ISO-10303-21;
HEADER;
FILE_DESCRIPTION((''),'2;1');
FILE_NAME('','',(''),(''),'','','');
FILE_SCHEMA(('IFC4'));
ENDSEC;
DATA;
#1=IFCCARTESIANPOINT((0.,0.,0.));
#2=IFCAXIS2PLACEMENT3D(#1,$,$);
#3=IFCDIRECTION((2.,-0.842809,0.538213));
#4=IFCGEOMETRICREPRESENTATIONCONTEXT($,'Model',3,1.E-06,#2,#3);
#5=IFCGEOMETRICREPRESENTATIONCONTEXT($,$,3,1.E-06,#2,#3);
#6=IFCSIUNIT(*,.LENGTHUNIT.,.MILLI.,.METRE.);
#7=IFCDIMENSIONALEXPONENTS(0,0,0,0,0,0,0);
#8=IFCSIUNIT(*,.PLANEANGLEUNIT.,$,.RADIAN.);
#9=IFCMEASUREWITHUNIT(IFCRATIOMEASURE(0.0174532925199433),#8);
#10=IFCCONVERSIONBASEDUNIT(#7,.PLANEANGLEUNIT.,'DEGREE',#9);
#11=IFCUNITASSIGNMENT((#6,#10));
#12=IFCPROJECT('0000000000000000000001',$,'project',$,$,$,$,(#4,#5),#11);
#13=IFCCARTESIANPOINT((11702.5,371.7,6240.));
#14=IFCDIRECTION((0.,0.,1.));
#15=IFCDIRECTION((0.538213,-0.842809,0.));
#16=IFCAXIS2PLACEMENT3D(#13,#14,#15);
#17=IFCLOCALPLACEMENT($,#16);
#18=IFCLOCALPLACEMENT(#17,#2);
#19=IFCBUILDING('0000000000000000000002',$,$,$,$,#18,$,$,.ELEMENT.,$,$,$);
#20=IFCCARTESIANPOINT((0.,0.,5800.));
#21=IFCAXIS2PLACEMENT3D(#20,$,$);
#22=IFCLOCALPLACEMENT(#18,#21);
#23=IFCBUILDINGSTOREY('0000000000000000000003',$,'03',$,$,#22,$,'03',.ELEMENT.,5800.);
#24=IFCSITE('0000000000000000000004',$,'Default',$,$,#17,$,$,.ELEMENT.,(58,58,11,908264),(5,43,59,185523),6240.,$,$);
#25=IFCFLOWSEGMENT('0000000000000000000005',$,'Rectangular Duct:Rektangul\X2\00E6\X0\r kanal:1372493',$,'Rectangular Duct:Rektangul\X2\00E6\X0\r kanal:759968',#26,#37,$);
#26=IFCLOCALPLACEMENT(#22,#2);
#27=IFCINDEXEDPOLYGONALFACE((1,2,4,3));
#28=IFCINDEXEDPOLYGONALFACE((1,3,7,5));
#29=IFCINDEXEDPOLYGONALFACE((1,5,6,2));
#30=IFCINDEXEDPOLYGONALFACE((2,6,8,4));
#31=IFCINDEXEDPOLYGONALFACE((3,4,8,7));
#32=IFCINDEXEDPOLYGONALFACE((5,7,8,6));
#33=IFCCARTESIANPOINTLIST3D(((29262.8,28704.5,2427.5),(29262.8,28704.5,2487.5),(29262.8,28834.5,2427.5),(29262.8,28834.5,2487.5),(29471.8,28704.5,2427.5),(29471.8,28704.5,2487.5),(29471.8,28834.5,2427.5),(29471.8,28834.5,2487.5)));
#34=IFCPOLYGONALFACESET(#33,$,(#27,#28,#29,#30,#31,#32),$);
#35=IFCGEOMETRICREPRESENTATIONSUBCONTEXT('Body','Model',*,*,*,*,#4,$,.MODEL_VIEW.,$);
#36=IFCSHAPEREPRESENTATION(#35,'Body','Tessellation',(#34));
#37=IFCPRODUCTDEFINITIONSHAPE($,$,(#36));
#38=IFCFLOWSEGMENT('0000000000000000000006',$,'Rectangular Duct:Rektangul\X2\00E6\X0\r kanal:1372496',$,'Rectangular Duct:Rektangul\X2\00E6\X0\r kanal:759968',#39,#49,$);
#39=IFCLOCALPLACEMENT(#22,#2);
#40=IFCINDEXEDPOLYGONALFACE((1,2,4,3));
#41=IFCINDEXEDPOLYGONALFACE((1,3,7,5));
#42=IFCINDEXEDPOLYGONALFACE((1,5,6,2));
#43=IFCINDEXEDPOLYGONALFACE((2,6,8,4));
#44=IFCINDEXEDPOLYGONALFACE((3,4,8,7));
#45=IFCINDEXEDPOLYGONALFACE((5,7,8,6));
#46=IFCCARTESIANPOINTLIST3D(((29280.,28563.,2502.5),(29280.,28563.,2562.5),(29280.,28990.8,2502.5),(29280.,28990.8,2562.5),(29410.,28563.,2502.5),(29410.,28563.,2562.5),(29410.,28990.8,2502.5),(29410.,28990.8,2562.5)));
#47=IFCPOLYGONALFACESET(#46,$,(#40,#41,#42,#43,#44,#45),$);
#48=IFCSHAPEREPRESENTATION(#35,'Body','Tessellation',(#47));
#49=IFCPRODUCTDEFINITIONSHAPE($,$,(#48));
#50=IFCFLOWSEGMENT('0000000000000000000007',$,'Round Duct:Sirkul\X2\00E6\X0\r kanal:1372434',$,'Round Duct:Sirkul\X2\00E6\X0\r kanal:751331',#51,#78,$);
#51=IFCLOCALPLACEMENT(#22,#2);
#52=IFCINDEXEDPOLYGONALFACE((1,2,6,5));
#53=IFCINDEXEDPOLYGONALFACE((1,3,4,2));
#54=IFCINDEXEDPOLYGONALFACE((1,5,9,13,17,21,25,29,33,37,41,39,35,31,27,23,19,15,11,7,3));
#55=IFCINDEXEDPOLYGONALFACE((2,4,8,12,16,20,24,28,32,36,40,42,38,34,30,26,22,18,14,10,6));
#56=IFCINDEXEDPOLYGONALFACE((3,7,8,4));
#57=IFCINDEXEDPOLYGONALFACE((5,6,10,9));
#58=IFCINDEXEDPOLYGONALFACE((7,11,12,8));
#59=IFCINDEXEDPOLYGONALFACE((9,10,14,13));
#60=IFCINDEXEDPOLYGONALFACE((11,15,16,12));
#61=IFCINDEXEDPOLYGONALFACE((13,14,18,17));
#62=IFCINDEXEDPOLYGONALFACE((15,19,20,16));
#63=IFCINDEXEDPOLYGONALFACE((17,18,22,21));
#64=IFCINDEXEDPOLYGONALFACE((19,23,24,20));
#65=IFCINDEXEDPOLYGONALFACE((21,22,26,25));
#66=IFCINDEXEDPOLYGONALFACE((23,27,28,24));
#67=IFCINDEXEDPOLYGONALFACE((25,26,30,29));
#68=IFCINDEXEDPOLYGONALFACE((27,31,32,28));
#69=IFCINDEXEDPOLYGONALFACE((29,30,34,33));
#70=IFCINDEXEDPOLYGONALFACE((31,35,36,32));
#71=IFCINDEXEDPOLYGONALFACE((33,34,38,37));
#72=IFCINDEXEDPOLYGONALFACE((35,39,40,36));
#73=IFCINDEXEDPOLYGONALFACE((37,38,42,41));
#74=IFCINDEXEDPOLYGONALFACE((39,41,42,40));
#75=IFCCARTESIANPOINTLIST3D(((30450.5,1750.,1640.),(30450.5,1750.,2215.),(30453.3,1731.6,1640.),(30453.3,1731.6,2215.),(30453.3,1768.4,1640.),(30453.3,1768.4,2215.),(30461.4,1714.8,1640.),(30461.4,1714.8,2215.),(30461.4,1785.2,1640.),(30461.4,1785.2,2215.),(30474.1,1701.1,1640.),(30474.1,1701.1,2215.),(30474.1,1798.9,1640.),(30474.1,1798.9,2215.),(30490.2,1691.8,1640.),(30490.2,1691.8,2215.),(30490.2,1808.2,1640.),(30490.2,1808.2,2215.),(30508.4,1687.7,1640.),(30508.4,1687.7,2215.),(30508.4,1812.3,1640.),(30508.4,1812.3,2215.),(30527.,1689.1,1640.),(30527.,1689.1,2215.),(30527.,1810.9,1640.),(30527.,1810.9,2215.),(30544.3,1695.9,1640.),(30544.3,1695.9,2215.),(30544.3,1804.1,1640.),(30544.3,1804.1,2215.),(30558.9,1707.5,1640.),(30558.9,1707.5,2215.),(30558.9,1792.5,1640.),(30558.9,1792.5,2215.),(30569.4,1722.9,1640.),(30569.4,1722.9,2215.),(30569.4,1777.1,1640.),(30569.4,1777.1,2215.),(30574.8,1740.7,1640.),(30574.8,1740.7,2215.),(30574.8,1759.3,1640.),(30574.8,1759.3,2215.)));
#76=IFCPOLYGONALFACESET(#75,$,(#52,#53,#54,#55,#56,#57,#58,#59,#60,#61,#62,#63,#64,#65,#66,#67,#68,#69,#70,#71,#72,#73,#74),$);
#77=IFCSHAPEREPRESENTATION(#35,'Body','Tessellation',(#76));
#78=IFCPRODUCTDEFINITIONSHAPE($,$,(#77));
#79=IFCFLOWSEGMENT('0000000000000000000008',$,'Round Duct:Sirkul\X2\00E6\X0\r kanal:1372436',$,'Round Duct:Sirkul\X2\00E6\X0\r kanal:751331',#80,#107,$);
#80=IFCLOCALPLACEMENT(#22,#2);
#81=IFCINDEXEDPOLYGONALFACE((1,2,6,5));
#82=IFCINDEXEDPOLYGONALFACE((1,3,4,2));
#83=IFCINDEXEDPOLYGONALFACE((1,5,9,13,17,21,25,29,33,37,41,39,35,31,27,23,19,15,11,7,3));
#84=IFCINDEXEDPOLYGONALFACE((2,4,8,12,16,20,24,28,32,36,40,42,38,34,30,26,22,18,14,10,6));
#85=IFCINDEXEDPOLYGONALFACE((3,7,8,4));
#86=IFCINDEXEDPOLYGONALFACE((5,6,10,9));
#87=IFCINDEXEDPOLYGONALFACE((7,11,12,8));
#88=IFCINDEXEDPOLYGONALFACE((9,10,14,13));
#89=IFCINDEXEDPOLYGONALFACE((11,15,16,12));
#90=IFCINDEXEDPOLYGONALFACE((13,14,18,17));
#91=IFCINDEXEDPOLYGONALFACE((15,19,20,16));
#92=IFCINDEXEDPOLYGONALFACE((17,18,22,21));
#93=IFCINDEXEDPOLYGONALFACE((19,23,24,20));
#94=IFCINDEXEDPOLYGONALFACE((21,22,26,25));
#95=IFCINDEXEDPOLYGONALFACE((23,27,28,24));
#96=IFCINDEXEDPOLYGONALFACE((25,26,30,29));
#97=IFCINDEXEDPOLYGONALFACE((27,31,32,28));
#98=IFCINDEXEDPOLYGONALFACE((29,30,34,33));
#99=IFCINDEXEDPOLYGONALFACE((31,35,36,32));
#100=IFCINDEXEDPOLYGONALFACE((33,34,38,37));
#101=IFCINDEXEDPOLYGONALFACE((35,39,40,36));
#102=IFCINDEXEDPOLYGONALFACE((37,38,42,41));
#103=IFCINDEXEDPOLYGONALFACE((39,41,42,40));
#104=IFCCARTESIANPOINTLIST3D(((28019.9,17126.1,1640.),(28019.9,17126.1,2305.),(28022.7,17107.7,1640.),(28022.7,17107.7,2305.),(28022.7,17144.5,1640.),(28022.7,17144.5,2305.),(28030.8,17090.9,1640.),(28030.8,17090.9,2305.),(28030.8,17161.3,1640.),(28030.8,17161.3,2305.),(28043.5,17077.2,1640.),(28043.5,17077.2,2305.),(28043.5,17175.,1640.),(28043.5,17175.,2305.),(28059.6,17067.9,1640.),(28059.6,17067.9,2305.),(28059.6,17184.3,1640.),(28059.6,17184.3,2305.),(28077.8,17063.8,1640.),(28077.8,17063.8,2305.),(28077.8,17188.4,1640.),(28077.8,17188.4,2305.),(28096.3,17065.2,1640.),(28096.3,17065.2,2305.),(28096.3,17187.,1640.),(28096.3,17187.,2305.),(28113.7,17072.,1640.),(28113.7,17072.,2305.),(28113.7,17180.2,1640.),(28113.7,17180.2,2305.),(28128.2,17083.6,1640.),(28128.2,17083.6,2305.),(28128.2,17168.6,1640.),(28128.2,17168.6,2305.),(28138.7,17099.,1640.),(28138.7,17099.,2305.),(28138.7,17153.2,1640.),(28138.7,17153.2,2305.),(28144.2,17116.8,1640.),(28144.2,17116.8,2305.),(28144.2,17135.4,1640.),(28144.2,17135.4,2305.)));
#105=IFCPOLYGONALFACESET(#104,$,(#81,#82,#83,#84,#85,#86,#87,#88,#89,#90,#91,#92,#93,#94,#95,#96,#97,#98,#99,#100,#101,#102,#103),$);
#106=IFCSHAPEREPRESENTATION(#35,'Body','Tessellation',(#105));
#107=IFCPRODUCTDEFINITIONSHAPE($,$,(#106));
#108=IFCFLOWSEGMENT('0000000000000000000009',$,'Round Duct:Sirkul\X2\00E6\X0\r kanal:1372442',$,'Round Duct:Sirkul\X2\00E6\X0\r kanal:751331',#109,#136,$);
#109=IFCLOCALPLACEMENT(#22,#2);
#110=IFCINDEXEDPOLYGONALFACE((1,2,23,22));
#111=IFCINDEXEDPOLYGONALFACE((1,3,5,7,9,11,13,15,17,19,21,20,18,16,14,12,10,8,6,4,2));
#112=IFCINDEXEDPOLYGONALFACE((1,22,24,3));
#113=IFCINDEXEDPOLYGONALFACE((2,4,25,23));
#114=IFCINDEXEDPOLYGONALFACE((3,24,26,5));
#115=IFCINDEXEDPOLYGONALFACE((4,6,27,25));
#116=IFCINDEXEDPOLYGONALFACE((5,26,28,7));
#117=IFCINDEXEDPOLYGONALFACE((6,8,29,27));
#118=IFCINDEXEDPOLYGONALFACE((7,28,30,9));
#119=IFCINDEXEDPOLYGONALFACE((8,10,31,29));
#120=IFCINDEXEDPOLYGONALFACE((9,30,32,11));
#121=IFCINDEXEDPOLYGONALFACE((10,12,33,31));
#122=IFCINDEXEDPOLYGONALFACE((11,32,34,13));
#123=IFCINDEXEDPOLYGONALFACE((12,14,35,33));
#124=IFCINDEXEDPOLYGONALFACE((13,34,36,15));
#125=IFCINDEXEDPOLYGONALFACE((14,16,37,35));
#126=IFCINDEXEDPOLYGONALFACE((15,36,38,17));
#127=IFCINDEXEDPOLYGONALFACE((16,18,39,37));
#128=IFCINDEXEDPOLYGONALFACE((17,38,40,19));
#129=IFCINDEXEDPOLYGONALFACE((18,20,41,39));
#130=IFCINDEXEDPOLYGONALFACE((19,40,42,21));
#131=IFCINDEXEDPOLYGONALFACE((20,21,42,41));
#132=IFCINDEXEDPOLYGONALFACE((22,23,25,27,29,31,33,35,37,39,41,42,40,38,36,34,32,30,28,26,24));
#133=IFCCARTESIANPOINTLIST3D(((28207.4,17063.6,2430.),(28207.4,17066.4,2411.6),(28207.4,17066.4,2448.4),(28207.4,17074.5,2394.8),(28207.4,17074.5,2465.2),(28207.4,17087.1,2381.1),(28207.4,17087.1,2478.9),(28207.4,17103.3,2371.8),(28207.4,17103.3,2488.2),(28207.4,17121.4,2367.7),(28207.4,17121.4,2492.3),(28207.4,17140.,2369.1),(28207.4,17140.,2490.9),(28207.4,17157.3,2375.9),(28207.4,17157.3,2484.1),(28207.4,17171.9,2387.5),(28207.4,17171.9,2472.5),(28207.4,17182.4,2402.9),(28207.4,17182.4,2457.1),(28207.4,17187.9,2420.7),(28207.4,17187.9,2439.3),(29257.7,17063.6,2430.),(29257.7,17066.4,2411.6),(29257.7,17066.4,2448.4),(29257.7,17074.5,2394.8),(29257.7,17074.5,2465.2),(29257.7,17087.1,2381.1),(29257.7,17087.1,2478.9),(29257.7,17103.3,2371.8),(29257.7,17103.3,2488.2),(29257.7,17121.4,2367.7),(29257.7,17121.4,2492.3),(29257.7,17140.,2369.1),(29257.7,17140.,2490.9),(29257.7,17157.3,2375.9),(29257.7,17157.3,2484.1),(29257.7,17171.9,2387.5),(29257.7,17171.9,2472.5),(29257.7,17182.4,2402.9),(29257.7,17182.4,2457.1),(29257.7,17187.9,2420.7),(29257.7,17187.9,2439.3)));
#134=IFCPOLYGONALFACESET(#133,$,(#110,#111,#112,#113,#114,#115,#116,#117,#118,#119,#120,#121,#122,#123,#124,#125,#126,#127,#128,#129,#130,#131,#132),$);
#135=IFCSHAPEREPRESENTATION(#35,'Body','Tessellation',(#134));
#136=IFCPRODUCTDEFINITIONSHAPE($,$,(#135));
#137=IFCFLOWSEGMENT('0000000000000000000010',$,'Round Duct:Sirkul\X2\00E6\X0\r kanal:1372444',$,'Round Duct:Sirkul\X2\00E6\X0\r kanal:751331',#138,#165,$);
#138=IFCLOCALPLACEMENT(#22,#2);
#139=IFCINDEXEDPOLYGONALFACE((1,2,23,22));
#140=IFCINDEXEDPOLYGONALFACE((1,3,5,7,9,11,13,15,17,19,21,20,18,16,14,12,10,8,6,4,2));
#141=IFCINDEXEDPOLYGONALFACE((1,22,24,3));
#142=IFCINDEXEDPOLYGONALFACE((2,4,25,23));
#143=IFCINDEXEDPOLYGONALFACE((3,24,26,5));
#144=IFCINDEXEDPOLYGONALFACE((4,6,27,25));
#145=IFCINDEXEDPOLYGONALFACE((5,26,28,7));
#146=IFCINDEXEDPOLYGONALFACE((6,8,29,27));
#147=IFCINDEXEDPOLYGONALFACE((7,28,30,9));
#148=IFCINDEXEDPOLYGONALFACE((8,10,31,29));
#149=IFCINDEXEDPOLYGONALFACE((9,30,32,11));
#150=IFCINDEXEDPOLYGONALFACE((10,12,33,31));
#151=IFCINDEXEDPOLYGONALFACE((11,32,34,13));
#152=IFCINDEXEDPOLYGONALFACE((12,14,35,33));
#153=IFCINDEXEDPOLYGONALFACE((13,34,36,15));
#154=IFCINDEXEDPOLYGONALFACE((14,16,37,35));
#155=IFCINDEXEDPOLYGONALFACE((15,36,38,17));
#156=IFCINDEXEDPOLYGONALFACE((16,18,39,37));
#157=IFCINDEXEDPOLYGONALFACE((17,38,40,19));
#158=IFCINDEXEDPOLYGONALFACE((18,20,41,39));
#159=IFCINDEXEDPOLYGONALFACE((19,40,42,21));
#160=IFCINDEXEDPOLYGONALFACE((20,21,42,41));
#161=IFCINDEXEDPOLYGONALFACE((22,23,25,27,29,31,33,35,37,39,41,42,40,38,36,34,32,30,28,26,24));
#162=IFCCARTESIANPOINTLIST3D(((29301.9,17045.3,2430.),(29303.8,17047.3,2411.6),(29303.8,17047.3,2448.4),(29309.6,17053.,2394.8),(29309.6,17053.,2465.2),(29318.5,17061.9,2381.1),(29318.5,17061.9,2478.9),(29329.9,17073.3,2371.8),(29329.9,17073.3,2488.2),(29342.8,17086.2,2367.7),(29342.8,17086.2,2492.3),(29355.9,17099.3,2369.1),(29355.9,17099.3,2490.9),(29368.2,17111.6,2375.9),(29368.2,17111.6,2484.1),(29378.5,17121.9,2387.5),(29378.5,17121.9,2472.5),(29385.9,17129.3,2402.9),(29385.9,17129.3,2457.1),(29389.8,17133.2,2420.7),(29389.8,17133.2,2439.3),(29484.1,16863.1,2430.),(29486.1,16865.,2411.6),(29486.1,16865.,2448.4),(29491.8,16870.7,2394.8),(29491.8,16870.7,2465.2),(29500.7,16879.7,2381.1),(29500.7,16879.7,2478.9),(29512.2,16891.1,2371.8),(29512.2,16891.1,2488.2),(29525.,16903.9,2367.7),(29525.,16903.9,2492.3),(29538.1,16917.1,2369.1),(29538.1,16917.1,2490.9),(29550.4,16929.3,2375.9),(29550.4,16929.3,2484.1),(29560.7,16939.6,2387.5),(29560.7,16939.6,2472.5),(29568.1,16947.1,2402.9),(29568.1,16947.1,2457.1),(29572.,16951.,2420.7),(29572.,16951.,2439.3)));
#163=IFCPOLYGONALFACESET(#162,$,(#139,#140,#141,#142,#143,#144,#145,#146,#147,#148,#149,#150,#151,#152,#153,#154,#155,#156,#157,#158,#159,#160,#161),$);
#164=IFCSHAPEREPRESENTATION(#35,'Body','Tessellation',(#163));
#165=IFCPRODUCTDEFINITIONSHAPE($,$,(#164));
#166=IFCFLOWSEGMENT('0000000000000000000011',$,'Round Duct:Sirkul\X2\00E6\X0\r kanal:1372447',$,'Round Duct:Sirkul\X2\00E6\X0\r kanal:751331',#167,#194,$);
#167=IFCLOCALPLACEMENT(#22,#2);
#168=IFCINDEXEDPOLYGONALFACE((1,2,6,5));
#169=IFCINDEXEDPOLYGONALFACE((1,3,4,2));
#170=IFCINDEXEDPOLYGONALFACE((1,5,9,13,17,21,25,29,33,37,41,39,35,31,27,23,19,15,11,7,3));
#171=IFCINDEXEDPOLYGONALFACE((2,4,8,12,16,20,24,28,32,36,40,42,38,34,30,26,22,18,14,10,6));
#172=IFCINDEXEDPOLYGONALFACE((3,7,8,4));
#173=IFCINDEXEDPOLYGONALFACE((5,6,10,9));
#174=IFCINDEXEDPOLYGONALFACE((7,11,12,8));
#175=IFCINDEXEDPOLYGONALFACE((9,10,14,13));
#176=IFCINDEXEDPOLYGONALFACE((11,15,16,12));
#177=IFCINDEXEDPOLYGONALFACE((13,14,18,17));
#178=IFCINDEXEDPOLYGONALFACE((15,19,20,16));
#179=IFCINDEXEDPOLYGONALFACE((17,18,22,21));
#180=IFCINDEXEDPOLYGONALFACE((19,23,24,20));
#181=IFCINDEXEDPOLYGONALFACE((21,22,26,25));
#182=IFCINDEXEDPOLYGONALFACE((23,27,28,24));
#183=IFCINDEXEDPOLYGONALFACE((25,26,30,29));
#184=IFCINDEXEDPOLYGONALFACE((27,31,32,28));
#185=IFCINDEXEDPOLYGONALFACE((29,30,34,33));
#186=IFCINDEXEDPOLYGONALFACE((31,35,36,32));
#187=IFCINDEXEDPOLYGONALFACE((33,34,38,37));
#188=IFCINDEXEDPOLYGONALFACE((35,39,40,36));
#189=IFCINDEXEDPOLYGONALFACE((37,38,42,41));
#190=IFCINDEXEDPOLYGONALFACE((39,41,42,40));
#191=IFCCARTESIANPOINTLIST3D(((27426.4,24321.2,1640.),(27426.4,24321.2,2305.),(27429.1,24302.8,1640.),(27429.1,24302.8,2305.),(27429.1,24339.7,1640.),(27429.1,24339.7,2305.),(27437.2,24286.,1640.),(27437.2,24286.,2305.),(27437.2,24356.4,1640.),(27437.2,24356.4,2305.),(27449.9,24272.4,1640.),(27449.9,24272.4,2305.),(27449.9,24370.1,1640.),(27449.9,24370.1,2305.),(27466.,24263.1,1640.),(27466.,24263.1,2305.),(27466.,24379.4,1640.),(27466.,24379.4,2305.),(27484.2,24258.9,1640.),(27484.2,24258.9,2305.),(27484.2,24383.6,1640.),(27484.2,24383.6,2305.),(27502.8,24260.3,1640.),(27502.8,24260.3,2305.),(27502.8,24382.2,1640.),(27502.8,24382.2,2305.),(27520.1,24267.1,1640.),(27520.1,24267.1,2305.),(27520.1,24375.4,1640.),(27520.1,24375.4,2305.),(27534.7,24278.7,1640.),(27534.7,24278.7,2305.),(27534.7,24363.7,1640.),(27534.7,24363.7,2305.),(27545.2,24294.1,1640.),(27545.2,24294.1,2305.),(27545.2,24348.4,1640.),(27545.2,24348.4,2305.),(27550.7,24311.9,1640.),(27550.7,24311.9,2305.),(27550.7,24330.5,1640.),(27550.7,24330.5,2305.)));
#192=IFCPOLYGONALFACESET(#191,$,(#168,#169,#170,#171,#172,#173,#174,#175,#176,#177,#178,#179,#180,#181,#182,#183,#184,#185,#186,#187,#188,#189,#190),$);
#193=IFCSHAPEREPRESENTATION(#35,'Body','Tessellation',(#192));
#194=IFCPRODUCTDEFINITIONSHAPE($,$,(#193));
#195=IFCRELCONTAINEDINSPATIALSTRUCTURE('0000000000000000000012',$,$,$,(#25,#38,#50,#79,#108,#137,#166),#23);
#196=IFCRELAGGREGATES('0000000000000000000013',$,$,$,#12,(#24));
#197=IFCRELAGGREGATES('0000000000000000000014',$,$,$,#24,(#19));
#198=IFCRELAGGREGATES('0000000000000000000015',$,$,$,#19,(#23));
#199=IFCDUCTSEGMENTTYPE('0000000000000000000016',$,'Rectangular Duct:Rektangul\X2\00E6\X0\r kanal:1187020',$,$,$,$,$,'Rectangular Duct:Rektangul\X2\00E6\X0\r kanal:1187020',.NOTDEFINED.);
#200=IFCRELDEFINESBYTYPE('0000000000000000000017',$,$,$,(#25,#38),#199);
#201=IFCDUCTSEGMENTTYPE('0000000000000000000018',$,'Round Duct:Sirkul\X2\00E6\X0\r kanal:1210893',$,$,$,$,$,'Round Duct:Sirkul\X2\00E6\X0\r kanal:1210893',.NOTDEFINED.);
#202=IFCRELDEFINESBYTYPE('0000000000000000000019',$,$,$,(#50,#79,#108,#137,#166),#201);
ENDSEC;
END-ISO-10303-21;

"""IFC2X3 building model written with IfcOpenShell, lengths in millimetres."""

from ifc_helpers import new_model, entity, si_unit, converted_unit, direction, frame, frame_2d, origin, origin_2d_with_axis, place, context, subcontext, project, spatial, rectangle, circle, extrude, type_object, element, save


model = new_model("IFC2X3")

# Units and contexts
model_context = context("Model", 3, precision=1e-06, world=origin(), true_north=direction((2.0, -0.842809, 0.538213)))
context_of_model = context(None, 3, precision=1e-06, world=origin(), true_north=direction((2.0, -0.842809, 0.538213)))
body_context = subcontext(model_context, "Body", "Model", "MODEL_VIEW")
ifc_project = project(units=[si_unit("LENGTHUNIT", "METRE", prefix="MILLI"), converted_unit("PLANEANGLEUNIT", "DEGREE", entity("IfcRatioMeasure", 0.0174532925199433), si_unit("PLANEANGLEUNIT", "RADIAN"), dimensions=[0, 0, 0, 0, 0, 0, 0])], contexts=[model_context, context_of_model])

# Site, building, storey
site_placement = place(None, frame((11702.5, 371.7, 6240.0), z_axis=(0.0, 0.0, 1.0), x_axis=(0.538213, -0.842809, 0.0)))
site = spatial("IfcSite", under=ifc_project, at=site_placement, Name="Default", CompositionType="ELEMENT", RefLatitude=(58, 58, 11, 908264), RefLongitude=(5, 43, 59, 185523), RefElevation=6240.0)
building_placement = place(site_placement, origin())
building = spatial("IfcBuilding", under=site, at=building_placement, CompositionType="ELEMENT")
storey_placement = place(building_placement, frame((0.0, 0.0, 5800.0)))
storey = spatial("IfcBuildingStorey", under=building, at=storey_placement, Name="03", LongName="03", CompositionType="ELEMENT", Elevation=5800.0)

# Flow segments
duct_segment_type_1 = type_object("IfcDuctSegmentType", Name="Rectangular Duct:Rektangulær kanal:1187020", ElementType="Rectangular Duct:Rektangulær kanal:1187020", PredefinedType="NOTDEFINED")
flow_segment_1_placement = place(storey_placement, origin())
element("IfcFlowSegment", 1, at=flow_segment_1_placement, inside=storey, type_object=duct_segment_type_1, Name="Rectangular Duct:Rektangulær kanal:1372493", ObjectType="Rectangular Duct:Rektangulær kanal:759968", context=body_context, shape_type="SweptSolid", body=[
    extrude(rectangle(XDim=208.9, YDim=130.0, at=frame_2d((0.0, 0.0), x_axis=(1.0, 0.0))), frame((29367.3, 28769.5, 2427.5), z_axis=(0.0, 0.0, 1.0), x_axis=(-1.0, 0.0, 0.0)), (0.0, 0.0, 1.0), 60.0),
])
flow_segment_2_placement = place(storey_placement, origin())
element("IfcFlowSegment", 2, at=flow_segment_2_placement, inside=storey, type_object=duct_segment_type_1, Name="Rectangular Duct:Rektangulær kanal:1372496", ObjectType="Rectangular Duct:Rektangulær kanal:759968", context=body_context, shape_type="SweptSolid", body=[
    extrude(rectangle(XDim=427.8, YDim=130.0, at=frame_2d((0.0, 0.0), x_axis=(1.0, 0.0))), frame((29345.0, 28776.9, 2502.5), z_axis=(0.0, 0.0, 1.0), x_axis=(0.0, 1.0, 0.0)), (0.0, 0.0, 1.0), 60.0),
])
duct_segment_type_2 = type_object("IfcDuctSegmentType", Name="Round Duct:Sirkulær kanal:1210893", ElementType="Round Duct:Sirkulær kanal:1210893", PredefinedType="NOTDEFINED")
flow_segment_3_placement = place(storey_placement, origin())
element("IfcFlowSegment", 3, at=flow_segment_3_placement, inside=storey, type_object=duct_segment_type_2, Name="Round Duct:Sirkulær kanal:1372434", ObjectType="Round Duct:Sirkulær kanal:751331", context=body_context, shape_type="SweptSolid", body=[
    extrude(circle(Radius=62.5, at=frame_2d((0.0, 0.0), x_axis=(1.0, 0.0))), frame((30513.0, 1750.0, 1640.0), z_axis=(0.0, 0.0, 1.0), x_axis=(-1.0, 0.0, 0.0)), (0.0, 0.0, 1.0), 575.0),
])
flow_segment_4_placement = place(storey_placement, origin())
element("IfcFlowSegment", 4, at=flow_segment_4_placement, inside=storey, type_object=duct_segment_type_2, Name="Round Duct:Sirkulær kanal:1372436", ObjectType="Round Duct:Sirkulær kanal:751331", context=body_context, shape_type="SweptSolid", body=[
    extrude(circle(Radius=62.5, at=origin_2d_with_axis()), frame((28082.4, 17126.1, 1640.0), z_axis=(0.0, 0.0, 1.0), x_axis=(-1.0, 0.0, 0.0)), (0.0, 0.0, 1.0), 665.0),
])
flow_segment_5_placement = place(storey_placement, origin())
element("IfcFlowSegment", 5, at=flow_segment_5_placement, inside=storey, type_object=duct_segment_type_2, Name="Round Duct:Sirkulær kanal:1372442", ObjectType="Round Duct:Sirkulær kanal:751331", context=body_context, shape_type="SweptSolid", body=[
    extrude(circle(Radius=62.5, at=origin_2d_with_axis()), frame((28207.4, 17126.1, 2430.0), z_axis=(1.0, 0.0, 0.0), x_axis=(0.0, -1.0, 0.0)), (0.0, 0.0, 1.0), 1050.2),
])
flow_segment_6_placement = place(storey_placement, origin())
element("IfcFlowSegment", 6, at=flow_segment_6_placement, inside=storey, type_object=duct_segment_type_2, Name="Round Duct:Sirkulær kanal:1372444", ObjectType="Round Duct:Sirkulær kanal:751331", context=body_context, shape_type="SweptSolid", body=[
    extrude(circle(Radius=62.5, at=origin_2d_with_axis()), frame((29346.1, 17089.5, 2430.0), z_axis=(0.707107, -0.707107, 0.0), x_axis=(-0.707107, -0.707107, 0.0)), (0.0, 0.0, 1.0), 257.7),
])
flow_segment_7_placement = place(storey_placement, origin())
element("IfcFlowSegment", 7, at=flow_segment_7_placement, inside=storey, type_object=duct_segment_type_2, Name="Round Duct:Sirkulær kanal:1372447", ObjectType="Round Duct:Sirkulær kanal:751331", context=body_context, shape_type="SweptSolid", body=[
    extrude(circle(Radius=62.5, at=origin_2d_with_axis()), frame((27488.9, 24321.2, 1640.0), z_axis=(0.0, 0.0, 1.0), x_axis=(-1.0, 0.0, 0.0)), (0.0, 0.0, 1.0), 665.0),
])

save(model, "model.ifc")
